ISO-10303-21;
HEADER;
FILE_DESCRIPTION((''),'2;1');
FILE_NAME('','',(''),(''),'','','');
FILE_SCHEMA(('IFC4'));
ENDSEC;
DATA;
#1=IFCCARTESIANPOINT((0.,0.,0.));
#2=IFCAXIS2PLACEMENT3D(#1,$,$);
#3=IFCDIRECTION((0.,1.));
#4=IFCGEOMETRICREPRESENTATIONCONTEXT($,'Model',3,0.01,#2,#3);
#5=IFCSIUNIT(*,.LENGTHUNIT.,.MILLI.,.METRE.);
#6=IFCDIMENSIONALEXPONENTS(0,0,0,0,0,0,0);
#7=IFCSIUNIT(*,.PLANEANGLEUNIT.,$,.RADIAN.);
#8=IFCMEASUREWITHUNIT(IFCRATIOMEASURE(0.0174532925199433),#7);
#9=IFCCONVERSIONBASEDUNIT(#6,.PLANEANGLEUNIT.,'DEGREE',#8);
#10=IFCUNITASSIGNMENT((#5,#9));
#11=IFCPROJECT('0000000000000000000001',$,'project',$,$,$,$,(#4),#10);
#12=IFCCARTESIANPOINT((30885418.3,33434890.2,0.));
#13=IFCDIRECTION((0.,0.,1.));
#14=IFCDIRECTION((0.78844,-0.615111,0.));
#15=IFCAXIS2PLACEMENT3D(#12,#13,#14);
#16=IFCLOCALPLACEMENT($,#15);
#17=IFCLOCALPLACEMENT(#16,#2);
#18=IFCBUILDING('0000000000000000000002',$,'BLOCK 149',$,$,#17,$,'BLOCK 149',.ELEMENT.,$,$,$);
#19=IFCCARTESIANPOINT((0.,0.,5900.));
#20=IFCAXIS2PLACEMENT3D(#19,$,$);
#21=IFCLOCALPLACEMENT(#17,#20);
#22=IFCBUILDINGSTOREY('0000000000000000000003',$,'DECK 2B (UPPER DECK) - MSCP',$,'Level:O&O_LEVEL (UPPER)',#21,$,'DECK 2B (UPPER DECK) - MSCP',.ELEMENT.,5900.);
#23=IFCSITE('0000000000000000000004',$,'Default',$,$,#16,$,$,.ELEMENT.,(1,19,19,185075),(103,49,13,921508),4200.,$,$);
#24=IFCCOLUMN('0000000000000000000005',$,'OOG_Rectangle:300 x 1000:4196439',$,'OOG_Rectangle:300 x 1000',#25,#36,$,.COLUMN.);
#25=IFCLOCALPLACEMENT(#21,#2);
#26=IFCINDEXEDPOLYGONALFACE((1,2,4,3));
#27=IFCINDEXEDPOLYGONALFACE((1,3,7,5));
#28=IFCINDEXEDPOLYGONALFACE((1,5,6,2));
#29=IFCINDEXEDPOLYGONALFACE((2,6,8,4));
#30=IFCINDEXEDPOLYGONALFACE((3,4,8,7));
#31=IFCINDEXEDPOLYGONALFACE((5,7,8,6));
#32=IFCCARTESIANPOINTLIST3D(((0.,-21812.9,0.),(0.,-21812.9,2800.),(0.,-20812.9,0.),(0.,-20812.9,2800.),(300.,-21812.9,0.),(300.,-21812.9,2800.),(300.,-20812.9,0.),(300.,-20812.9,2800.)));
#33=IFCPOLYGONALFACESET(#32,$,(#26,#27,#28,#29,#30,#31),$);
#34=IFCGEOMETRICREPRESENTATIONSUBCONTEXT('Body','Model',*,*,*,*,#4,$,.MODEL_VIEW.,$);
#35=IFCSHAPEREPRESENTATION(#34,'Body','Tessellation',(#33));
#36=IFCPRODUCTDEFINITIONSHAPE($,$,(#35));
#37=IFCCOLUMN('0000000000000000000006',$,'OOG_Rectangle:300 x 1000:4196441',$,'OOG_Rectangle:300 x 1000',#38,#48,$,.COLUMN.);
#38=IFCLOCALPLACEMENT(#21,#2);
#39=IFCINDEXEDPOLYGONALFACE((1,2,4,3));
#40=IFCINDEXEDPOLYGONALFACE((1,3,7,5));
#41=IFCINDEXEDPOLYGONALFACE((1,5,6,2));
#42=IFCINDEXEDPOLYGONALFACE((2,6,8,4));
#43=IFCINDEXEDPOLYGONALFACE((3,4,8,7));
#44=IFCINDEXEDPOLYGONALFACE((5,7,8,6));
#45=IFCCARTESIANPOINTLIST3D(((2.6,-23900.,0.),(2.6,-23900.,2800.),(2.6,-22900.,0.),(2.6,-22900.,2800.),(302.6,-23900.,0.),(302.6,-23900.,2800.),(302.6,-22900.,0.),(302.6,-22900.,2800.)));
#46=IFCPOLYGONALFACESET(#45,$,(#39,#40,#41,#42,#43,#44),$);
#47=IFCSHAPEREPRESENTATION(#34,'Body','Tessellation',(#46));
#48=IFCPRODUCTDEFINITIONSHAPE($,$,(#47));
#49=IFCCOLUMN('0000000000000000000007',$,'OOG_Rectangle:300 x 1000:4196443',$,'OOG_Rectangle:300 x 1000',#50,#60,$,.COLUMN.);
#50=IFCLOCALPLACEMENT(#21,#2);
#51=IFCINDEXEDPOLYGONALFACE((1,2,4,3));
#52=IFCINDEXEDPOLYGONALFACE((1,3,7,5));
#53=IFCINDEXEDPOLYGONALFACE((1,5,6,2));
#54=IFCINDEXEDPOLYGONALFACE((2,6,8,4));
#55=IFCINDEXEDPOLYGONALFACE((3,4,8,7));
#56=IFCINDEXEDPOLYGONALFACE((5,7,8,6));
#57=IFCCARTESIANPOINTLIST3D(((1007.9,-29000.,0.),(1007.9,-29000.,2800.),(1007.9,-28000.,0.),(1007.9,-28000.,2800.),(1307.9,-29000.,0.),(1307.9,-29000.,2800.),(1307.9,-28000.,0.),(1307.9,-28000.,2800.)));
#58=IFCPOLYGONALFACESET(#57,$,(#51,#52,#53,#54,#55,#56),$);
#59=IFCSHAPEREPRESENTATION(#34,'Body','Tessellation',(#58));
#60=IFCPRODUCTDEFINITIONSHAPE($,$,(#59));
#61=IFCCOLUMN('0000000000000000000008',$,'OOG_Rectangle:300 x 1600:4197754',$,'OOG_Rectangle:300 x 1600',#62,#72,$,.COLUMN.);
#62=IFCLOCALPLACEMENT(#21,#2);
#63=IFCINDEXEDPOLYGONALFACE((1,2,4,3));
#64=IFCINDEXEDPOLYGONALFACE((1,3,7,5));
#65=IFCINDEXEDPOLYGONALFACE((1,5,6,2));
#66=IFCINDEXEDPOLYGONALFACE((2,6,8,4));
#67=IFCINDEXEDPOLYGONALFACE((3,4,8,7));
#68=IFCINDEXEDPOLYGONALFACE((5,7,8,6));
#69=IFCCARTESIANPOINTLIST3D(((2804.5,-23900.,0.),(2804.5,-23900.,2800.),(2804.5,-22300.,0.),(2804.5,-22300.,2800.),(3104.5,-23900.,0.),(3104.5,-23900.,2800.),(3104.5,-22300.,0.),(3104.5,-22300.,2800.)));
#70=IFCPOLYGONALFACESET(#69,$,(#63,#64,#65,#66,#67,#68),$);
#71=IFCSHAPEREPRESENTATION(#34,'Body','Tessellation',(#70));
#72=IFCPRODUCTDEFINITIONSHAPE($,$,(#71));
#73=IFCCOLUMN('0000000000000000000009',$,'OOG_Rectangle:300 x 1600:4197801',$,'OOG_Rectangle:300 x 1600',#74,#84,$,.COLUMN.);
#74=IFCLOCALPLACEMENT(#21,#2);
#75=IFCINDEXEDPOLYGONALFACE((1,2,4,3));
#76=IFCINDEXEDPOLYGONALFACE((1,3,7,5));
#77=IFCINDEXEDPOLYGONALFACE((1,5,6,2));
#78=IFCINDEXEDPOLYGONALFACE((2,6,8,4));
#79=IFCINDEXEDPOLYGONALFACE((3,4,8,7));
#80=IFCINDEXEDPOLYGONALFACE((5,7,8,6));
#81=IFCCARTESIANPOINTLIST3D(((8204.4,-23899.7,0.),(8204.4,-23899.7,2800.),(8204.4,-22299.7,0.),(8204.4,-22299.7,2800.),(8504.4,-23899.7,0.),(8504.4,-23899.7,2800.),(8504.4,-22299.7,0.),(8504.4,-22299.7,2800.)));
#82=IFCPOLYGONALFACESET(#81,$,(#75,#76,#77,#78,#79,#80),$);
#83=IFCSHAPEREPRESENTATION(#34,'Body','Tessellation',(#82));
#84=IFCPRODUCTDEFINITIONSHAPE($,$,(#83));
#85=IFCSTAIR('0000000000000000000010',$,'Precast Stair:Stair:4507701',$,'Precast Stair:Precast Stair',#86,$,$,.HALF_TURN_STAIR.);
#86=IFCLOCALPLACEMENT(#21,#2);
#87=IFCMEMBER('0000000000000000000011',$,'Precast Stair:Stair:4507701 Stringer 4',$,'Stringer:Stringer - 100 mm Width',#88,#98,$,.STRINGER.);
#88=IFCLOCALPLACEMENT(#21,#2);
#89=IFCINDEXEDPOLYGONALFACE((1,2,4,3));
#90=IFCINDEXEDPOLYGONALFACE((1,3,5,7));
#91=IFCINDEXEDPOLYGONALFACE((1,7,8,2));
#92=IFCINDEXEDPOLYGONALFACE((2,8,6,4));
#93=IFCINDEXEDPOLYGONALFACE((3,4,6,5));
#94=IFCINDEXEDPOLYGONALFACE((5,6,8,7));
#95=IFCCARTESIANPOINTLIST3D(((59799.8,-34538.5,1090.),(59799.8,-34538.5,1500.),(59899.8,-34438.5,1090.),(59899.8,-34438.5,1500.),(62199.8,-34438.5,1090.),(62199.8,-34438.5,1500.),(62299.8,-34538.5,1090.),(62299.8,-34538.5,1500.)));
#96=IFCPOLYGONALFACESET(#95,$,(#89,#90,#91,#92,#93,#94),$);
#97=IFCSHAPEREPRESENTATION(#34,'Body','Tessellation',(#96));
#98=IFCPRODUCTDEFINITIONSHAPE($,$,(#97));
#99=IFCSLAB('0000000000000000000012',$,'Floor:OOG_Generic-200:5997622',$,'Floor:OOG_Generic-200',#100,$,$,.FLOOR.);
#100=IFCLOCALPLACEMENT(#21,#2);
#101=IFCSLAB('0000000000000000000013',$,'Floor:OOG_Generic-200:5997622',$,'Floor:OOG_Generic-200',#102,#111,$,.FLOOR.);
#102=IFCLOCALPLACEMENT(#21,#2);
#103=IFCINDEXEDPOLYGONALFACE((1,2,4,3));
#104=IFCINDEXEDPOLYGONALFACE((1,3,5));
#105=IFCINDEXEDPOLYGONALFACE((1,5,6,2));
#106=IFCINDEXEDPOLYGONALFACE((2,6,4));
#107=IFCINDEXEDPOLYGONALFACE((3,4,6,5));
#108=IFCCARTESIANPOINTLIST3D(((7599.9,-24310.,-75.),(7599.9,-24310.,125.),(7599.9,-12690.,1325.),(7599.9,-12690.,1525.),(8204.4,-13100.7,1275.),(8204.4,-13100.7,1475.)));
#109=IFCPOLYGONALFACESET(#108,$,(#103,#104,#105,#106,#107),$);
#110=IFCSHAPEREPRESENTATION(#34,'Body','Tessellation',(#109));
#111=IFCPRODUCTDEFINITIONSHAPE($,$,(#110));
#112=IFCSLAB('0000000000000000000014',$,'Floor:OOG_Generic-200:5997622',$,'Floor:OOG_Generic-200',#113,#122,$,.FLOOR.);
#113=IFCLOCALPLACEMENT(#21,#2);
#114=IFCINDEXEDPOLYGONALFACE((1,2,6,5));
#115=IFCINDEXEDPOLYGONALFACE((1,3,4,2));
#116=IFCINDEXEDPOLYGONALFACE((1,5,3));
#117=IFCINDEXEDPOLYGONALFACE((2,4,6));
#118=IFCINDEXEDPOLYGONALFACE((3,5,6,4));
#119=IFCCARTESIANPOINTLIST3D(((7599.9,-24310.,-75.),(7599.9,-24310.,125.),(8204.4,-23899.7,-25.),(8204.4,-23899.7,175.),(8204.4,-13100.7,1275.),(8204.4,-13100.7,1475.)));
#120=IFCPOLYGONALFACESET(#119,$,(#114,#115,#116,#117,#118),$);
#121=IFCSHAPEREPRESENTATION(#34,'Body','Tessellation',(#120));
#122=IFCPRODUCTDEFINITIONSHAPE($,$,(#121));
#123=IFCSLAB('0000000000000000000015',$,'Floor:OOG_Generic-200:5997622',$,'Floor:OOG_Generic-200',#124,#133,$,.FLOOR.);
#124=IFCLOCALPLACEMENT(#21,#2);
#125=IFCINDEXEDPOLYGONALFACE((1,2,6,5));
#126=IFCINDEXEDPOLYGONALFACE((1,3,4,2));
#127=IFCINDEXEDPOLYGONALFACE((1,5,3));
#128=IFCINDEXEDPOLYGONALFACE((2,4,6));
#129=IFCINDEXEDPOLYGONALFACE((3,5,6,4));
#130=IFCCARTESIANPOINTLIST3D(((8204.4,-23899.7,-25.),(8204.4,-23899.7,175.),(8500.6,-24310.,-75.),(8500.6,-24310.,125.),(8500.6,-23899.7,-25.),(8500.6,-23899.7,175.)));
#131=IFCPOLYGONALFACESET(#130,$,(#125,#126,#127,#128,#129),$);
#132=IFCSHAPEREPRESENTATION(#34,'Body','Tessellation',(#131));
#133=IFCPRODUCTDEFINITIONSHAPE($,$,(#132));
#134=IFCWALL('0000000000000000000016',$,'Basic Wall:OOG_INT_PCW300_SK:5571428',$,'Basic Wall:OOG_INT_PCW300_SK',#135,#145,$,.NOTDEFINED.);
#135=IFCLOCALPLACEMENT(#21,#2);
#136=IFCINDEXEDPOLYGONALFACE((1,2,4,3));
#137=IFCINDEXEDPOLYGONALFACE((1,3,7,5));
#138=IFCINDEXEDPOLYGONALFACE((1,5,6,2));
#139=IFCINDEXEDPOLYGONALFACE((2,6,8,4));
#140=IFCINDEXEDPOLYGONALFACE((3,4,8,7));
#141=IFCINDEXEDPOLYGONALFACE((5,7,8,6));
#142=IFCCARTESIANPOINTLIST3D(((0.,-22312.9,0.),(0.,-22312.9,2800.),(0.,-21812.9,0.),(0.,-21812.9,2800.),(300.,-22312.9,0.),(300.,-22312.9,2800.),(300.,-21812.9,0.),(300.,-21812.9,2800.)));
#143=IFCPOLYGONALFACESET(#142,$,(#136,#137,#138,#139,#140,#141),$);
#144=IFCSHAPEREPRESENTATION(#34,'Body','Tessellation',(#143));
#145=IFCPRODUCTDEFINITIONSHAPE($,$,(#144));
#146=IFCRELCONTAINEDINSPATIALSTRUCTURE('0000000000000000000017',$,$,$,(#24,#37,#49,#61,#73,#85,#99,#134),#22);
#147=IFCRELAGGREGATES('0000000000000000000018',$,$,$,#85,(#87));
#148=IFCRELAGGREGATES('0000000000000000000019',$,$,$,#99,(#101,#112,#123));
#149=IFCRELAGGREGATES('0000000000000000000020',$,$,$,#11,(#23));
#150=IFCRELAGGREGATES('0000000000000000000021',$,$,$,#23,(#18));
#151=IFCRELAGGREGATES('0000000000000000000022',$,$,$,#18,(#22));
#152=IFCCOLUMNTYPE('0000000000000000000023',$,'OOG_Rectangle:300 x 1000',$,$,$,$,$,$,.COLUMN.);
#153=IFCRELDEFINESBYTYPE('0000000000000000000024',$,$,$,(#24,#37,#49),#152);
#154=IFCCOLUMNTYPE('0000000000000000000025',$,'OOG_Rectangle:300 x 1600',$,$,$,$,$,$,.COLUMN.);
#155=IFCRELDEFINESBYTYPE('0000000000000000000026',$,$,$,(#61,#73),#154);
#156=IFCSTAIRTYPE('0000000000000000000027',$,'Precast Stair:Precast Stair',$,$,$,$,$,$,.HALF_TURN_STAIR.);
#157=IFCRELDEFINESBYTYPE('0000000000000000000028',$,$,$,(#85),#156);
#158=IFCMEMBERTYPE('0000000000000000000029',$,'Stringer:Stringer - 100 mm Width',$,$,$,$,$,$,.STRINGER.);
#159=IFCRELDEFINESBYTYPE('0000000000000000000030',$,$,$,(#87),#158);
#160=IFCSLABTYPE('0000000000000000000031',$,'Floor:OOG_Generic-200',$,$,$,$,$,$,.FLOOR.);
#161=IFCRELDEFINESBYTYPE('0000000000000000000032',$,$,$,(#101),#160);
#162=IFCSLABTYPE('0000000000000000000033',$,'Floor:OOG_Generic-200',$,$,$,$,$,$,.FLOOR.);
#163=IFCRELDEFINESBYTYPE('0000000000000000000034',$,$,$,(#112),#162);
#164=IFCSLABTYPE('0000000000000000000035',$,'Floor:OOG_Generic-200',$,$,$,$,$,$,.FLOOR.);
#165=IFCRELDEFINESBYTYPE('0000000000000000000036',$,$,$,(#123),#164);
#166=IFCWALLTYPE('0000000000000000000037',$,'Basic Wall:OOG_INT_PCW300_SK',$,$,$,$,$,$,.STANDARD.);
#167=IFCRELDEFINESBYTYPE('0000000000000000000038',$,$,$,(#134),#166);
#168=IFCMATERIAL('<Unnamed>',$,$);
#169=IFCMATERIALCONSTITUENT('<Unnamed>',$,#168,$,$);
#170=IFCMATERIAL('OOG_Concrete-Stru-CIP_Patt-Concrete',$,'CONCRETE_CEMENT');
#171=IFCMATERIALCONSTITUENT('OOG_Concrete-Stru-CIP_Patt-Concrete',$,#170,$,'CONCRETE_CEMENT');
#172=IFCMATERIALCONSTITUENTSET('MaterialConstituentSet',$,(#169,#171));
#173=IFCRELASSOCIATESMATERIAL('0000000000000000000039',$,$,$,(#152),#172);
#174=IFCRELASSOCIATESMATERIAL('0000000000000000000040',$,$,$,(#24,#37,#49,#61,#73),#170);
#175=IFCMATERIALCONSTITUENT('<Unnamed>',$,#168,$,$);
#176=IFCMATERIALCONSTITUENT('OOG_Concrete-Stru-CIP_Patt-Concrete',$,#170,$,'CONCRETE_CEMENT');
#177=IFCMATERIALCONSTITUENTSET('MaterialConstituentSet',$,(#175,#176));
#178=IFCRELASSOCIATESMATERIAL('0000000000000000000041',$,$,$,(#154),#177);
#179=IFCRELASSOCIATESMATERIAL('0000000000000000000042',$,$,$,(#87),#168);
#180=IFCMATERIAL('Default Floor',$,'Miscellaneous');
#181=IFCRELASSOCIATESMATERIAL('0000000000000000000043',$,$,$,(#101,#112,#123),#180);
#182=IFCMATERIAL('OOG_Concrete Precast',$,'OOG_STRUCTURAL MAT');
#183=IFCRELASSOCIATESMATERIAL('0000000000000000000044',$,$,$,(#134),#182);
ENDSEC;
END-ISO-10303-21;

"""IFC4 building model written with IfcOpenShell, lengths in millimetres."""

from ifc_helpers import new_model, entity, si_unit, converted_unit, direction, frame, origin, place, context, subcontext, project, spatial, indexed_curve, outline, extrude, source, transform, mapped, material, constituent, constituent_set, type_object, type_shapes, element, aggregate, save


model = new_model("IFC4")

# Units and contexts
model_context = context("Model", 3, precision=0.01, world=origin(), true_north=direction((0.0, 1.0)))
body_context = subcontext(model_context, "Body", "Model", "MODEL_VIEW")
ifc_project = project(units=[si_unit("LENGTHUNIT", "METRE", prefix="MILLI"), converted_unit("PLANEANGLEUNIT", "DEGREE", entity("IfcRatioMeasure", 0.0174532925199433), si_unit("PLANEANGLEUNIT", "RADIAN"), dimensions=[0, 0, 0, 0, 0, 0, 0])], contexts=[model_context])

# Site, building, storey
site_placement = place(None, frame((30885418.3, 33434890.2, 0.0), z_axis=(0.0, 0.0, 1.0), x_axis=(0.78844, -0.615111, 0.0)))
site = spatial("IfcSite", under=ifc_project, at=site_placement, Name="Default", CompositionType="ELEMENT", RefLatitude=(1, 19, 19, 185075), RefLongitude=(103, 49, 13, 921508), RefElevation=4200.0)
building_placement = place(site_placement, origin())
building = spatial("IfcBuilding", under=site, at=building_placement, Name="BLOCK 149", LongName="BLOCK 149", CompositionType="ELEMENT")
storey_placement = place(building_placement, frame((0.0, 0.0, 5900.0)))
storey = spatial("IfcBuildingStorey", under=building, at=storey_placement, Name="DECK 2B (UPPER DECK) - MSCP", ObjectType="Level:O&O_LEVEL (UPPER)", LongName="DECK 2B (UPPER DECK) - MSCP", CompositionType="ELEMENT", Elevation=5900.0)

# Columns
ifc_material_1 = material(Name="OOG_Concrete-Stru-CIP_Patt-Concrete", Category="CONCRETE_CEMENT")
ifc_material_2 = material(Name="<Unnamed>")
ifc_constituent_1 = constituent(ifc_material_2, Name="<Unnamed>")
ifc_constituent_2 = constituent(ifc_material_1, Name="OOG_Concrete-Stru-CIP_Patt-Concrete", Category="CONCRETE_CEMENT")
ifc_constituent_set_1 = constituent_set(constituents=[ifc_constituent_1, ifc_constituent_2], Name="MaterialConstituentSet")
column_type_1 = type_object("IfcColumnType", Name="OOG_Rectangle:300 x 1000", PredefinedType="COLUMN", material=ifc_constituent_set_1)
shared_shape_1 = source(origin(), body_context, "Body", "SweptSolid", [
    extrude(outline(indexed_curve([(-500.0, -150.0), (500.0, -150.0), (500.0, 150.0), (-500.0, 150.0), (-500.0, -150.0)], self_intersect=False)), frame((0.0, 0.0, 5900.0), z_axis=(0.0, 0.0, 1.0), x_axis=(0.0, -1.0, 0.0)), (0.0, 0.0, 1.0), 2800.0),
])
type_shapes(column_type_1, [shared_shape_1])
for number, where, name in (
    (1, (150.0, -21312.9, -5900.0), "OOG_Rectangle:300 x 1000:4196439"),
    (2, (152.6, -23400.0, -5900.0), "OOG_Rectangle:300 x 1000:4196441"),
    (3, (1157.9, -28500.0, -5900.0), "OOG_Rectangle:300 x 1000:4196443"),
):
    element("IfcColumn", number, at=place(storey_placement, frame(where)), inside=storey, type_object=column_type_1, material=ifc_material_1, Name=name, ObjectType="OOG_Rectangle:300 x 1000", PredefinedType="COLUMN", context=body_context, shape_type="MappedRepresentation", body=[
        mapped(shared_shape_1, transform((0.0, 0.0, 0.0), scale=1.0)),
    ])
ifc_constituent_3 = constituent(ifc_material_2, Name="<Unnamed>")
ifc_constituent_4 = constituent(ifc_material_1, Name="OOG_Concrete-Stru-CIP_Patt-Concrete", Category="CONCRETE_CEMENT")
ifc_constituent_set_2 = constituent_set(constituents=[ifc_constituent_3, ifc_constituent_4], Name="MaterialConstituentSet")
column_type_2 = type_object("IfcColumnType", Name="OOG_Rectangle:300 x 1600", PredefinedType="COLUMN", material=ifc_constituent_set_2)
shared_shape_2 = source(origin(), body_context, "Body", "SweptSolid", [
    extrude(outline(indexed_curve([(-800.0, -150.0), (800.0, -150.0), (800.0, 150.0), (-800.0, 150.0), (-800.0, -150.0)], self_intersect=False)), frame((0.0, 0.0, 5900.0), z_axis=(0.0, 0.0, 1.0), x_axis=(0.0, -1.0, 0.0)), (0.0, 0.0, 1.0), 2800.0),
])
type_shapes(column_type_2, [shared_shape_2])
for number, where, name in (
    (4, (2954.5, -23100.0, -5900.0), "OOG_Rectangle:300 x 1600:4197754"),
    (5, (8354.4, -23099.7, -5900.0), "OOG_Rectangle:300 x 1600:4197801"),
):
    element("IfcColumn", number, at=place(storey_placement, frame(where)), inside=storey, type_object=column_type_2, material=ifc_material_1, Name=name, ObjectType="OOG_Rectangle:300 x 1600", PredefinedType="COLUMN", context=body_context, shape_type="MappedRepresentation", body=[
        mapped(shared_shape_2, transform((0.0, 0.0, 0.0), scale=1.0)),
    ])

# Shared definitions
member_type = type_object("IfcMemberType", Name="Stringer:Stringer - 100 mm Width", PredefinedType="STRINGER")

# Stair, member
stair_type_1 = type_object("IfcStairType", Name="Precast Stair:Precast Stair", PredefinedType="HALF_TURN_STAIR")
stair_1_placement = place(storey_placement, origin())
stair_1 = element("IfcStair", 6, at=stair_1_placement, inside=storey, type_object=stair_type_1, Name="Precast Stair:Stair:4507701", ObjectType="Precast Stair:Precast Stair", PredefinedType="HALF_TURN_STAIR")
member_1_placement = place(stair_1_placement, origin())
member_1 = element("IfcMember", 7, at=member_1_placement, type_object=member_type, material=ifc_material_2, Name="Precast Stair:Stair:4507701 Stringer 4", ObjectType="Stringer:Stringer - 100 mm Width", PredefinedType="STRINGER", context=body_context, shape_type="SweptSolid", body=[
    extrude(outline(indexed_curve([(-1250.0, -50.0), (1250.0, -50.0), (1150.0, 50.0), (-1150.0, 50.0), (-1250.0, -50.0)], self_intersect=False)), frame((61049.8, -34488.5, 1090.0)), (0.0, 0.0, 1.0), 410.0),
])
aggregate(stair_1, [member_1])

# Slabs
ifc_material_3 = material(Name="Default Floor", Category="Miscellaneous")
slab_1_placement = place(storey_placement, frame((7599.9, -24310.0, -75.0)))
slab_1 = element("IfcSlab", 8, at=slab_1_placement, inside=storey, Name="Floor:OOG_Generic-200:5997622", ObjectType="Floor:OOG_Generic-200", PredefinedType="FLOOR")
slab_type_1 = type_object("IfcSlabType", Name="Floor:OOG_Generic-200", PredefinedType="FLOOR")
slab_2_placement = place(slab_1_placement, origin())
slab_2 = element("IfcSlab", 9, at=slab_2_placement, type_object=slab_type_1, material=ifc_material_3, Name="Floor:OOG_Generic-200:5997622", ObjectType="Floor:OOG_Generic-200", PredefinedType="FLOOR", context=body_context, shape_type="SweptSolid", body=[
    extrude(outline(indexed_curve([(-302.3, 5852.0), (-302.3, -5852.0), (302.3, 5438.2), (-302.3, 5852.0)], self_intersect=False)), frame((302.3, 5810.0, 899.7), z_axis=(0.000842, -0.119617, 0.99282), x_axis=(1.0, 0.000101, -0.000836)), (0.000836, -0.119617, -0.99282), 200.0),
])
slab_type_2 = type_object("IfcSlabType", Name="Floor:OOG_Generic-200", PredefinedType="FLOOR")
slab_3_placement = place(slab_1_placement, origin())
slab_3 = element("IfcSlab", 10, at=slab_3_placement, type_object=slab_type_2, material=ifc_material_3, Name="Floor:OOG_Generic-200:5997622", ObjectType="Floor:OOG_Generic-200", PredefinedType="FLOOR", context=body_context, shape_type="SweptSolid", body=[
    extrude(outline(indexed_curve([(-302.3, -5645.1), (302.3, -5231.8), (302.3, 5645.1), (-302.3, -5645.1)], self_intersect=False)), frame((302.3, 5604.6, 875.0), z_axis=(-0.001, -0.119519, 0.992831), x_axis=(0.999999, -0.00012, 0.000993)), (-0.000993, -0.119519, -0.992831), 200.0),
])
slab_type_3 = type_object("IfcSlabType", Name="Floor:OOG_Generic-200", PredefinedType="FLOOR")
slab_4_placement = place(slab_1_placement, origin())
slab_4 = element("IfcSlab", 11, at=slab_4_placement, type_object=slab_type_3, material=ifc_material_3, Name="Floor:OOG_Generic-200:5997622", ObjectType="Floor:OOG_Generic-200", PredefinedType="FLOOR", context=body_context, shape_type="SweptSolid", body=[
    extrude(outline(indexed_curve([(148.1, -206.7), (148.1, 206.7), (-148.1, 206.7), (148.1, -206.7)], self_intersect=False)), frame((752.6, 205.1, 225.0), z_axis=(0.0, -0.120972, 0.992656), x_axis=(1.0, 0.0, 0.0)), (0.0, -0.120972, -0.992656), 200.0),
])
aggregate(slab_1, [slab_2, slab_3, slab_4])

# Wall
ifc_material_4 = material(Name="OOG_Concrete Precast", Category="OOG_STRUCTURAL MAT")
wall_type = type_object("IfcWallType", Name="Basic Wall:OOG_INT_PCW300_SK", PredefinedType="STANDARD")
wall_placement = place(storey_placement, frame((150.0, -21812.9, 0.0), z_axis=(0.0, 0.0, 1.0), x_axis=(0.0, -1.0, 0.0)))
element("IfcWall", 12, at=wall_placement, inside=storey, type_object=wall_type, material=ifc_material_4, Name="Basic Wall:OOG_INT_PCW300_SK:5571428", ObjectType="Basic Wall:OOG_INT_PCW300_SK", PredefinedType="NOTDEFINED", context=body_context, shape_type="SweptSolid", body=[
    extrude(outline(indexed_curve([(500.0, 150.0), (0.0, 150.0), (0.0, -150.0), (500.0, -150.0), (500.0, 150.0)], self_intersect=False)), origin(), (0.0, 0.0, 1.0), 2800.0),
])

save(model, "model.ifc")
